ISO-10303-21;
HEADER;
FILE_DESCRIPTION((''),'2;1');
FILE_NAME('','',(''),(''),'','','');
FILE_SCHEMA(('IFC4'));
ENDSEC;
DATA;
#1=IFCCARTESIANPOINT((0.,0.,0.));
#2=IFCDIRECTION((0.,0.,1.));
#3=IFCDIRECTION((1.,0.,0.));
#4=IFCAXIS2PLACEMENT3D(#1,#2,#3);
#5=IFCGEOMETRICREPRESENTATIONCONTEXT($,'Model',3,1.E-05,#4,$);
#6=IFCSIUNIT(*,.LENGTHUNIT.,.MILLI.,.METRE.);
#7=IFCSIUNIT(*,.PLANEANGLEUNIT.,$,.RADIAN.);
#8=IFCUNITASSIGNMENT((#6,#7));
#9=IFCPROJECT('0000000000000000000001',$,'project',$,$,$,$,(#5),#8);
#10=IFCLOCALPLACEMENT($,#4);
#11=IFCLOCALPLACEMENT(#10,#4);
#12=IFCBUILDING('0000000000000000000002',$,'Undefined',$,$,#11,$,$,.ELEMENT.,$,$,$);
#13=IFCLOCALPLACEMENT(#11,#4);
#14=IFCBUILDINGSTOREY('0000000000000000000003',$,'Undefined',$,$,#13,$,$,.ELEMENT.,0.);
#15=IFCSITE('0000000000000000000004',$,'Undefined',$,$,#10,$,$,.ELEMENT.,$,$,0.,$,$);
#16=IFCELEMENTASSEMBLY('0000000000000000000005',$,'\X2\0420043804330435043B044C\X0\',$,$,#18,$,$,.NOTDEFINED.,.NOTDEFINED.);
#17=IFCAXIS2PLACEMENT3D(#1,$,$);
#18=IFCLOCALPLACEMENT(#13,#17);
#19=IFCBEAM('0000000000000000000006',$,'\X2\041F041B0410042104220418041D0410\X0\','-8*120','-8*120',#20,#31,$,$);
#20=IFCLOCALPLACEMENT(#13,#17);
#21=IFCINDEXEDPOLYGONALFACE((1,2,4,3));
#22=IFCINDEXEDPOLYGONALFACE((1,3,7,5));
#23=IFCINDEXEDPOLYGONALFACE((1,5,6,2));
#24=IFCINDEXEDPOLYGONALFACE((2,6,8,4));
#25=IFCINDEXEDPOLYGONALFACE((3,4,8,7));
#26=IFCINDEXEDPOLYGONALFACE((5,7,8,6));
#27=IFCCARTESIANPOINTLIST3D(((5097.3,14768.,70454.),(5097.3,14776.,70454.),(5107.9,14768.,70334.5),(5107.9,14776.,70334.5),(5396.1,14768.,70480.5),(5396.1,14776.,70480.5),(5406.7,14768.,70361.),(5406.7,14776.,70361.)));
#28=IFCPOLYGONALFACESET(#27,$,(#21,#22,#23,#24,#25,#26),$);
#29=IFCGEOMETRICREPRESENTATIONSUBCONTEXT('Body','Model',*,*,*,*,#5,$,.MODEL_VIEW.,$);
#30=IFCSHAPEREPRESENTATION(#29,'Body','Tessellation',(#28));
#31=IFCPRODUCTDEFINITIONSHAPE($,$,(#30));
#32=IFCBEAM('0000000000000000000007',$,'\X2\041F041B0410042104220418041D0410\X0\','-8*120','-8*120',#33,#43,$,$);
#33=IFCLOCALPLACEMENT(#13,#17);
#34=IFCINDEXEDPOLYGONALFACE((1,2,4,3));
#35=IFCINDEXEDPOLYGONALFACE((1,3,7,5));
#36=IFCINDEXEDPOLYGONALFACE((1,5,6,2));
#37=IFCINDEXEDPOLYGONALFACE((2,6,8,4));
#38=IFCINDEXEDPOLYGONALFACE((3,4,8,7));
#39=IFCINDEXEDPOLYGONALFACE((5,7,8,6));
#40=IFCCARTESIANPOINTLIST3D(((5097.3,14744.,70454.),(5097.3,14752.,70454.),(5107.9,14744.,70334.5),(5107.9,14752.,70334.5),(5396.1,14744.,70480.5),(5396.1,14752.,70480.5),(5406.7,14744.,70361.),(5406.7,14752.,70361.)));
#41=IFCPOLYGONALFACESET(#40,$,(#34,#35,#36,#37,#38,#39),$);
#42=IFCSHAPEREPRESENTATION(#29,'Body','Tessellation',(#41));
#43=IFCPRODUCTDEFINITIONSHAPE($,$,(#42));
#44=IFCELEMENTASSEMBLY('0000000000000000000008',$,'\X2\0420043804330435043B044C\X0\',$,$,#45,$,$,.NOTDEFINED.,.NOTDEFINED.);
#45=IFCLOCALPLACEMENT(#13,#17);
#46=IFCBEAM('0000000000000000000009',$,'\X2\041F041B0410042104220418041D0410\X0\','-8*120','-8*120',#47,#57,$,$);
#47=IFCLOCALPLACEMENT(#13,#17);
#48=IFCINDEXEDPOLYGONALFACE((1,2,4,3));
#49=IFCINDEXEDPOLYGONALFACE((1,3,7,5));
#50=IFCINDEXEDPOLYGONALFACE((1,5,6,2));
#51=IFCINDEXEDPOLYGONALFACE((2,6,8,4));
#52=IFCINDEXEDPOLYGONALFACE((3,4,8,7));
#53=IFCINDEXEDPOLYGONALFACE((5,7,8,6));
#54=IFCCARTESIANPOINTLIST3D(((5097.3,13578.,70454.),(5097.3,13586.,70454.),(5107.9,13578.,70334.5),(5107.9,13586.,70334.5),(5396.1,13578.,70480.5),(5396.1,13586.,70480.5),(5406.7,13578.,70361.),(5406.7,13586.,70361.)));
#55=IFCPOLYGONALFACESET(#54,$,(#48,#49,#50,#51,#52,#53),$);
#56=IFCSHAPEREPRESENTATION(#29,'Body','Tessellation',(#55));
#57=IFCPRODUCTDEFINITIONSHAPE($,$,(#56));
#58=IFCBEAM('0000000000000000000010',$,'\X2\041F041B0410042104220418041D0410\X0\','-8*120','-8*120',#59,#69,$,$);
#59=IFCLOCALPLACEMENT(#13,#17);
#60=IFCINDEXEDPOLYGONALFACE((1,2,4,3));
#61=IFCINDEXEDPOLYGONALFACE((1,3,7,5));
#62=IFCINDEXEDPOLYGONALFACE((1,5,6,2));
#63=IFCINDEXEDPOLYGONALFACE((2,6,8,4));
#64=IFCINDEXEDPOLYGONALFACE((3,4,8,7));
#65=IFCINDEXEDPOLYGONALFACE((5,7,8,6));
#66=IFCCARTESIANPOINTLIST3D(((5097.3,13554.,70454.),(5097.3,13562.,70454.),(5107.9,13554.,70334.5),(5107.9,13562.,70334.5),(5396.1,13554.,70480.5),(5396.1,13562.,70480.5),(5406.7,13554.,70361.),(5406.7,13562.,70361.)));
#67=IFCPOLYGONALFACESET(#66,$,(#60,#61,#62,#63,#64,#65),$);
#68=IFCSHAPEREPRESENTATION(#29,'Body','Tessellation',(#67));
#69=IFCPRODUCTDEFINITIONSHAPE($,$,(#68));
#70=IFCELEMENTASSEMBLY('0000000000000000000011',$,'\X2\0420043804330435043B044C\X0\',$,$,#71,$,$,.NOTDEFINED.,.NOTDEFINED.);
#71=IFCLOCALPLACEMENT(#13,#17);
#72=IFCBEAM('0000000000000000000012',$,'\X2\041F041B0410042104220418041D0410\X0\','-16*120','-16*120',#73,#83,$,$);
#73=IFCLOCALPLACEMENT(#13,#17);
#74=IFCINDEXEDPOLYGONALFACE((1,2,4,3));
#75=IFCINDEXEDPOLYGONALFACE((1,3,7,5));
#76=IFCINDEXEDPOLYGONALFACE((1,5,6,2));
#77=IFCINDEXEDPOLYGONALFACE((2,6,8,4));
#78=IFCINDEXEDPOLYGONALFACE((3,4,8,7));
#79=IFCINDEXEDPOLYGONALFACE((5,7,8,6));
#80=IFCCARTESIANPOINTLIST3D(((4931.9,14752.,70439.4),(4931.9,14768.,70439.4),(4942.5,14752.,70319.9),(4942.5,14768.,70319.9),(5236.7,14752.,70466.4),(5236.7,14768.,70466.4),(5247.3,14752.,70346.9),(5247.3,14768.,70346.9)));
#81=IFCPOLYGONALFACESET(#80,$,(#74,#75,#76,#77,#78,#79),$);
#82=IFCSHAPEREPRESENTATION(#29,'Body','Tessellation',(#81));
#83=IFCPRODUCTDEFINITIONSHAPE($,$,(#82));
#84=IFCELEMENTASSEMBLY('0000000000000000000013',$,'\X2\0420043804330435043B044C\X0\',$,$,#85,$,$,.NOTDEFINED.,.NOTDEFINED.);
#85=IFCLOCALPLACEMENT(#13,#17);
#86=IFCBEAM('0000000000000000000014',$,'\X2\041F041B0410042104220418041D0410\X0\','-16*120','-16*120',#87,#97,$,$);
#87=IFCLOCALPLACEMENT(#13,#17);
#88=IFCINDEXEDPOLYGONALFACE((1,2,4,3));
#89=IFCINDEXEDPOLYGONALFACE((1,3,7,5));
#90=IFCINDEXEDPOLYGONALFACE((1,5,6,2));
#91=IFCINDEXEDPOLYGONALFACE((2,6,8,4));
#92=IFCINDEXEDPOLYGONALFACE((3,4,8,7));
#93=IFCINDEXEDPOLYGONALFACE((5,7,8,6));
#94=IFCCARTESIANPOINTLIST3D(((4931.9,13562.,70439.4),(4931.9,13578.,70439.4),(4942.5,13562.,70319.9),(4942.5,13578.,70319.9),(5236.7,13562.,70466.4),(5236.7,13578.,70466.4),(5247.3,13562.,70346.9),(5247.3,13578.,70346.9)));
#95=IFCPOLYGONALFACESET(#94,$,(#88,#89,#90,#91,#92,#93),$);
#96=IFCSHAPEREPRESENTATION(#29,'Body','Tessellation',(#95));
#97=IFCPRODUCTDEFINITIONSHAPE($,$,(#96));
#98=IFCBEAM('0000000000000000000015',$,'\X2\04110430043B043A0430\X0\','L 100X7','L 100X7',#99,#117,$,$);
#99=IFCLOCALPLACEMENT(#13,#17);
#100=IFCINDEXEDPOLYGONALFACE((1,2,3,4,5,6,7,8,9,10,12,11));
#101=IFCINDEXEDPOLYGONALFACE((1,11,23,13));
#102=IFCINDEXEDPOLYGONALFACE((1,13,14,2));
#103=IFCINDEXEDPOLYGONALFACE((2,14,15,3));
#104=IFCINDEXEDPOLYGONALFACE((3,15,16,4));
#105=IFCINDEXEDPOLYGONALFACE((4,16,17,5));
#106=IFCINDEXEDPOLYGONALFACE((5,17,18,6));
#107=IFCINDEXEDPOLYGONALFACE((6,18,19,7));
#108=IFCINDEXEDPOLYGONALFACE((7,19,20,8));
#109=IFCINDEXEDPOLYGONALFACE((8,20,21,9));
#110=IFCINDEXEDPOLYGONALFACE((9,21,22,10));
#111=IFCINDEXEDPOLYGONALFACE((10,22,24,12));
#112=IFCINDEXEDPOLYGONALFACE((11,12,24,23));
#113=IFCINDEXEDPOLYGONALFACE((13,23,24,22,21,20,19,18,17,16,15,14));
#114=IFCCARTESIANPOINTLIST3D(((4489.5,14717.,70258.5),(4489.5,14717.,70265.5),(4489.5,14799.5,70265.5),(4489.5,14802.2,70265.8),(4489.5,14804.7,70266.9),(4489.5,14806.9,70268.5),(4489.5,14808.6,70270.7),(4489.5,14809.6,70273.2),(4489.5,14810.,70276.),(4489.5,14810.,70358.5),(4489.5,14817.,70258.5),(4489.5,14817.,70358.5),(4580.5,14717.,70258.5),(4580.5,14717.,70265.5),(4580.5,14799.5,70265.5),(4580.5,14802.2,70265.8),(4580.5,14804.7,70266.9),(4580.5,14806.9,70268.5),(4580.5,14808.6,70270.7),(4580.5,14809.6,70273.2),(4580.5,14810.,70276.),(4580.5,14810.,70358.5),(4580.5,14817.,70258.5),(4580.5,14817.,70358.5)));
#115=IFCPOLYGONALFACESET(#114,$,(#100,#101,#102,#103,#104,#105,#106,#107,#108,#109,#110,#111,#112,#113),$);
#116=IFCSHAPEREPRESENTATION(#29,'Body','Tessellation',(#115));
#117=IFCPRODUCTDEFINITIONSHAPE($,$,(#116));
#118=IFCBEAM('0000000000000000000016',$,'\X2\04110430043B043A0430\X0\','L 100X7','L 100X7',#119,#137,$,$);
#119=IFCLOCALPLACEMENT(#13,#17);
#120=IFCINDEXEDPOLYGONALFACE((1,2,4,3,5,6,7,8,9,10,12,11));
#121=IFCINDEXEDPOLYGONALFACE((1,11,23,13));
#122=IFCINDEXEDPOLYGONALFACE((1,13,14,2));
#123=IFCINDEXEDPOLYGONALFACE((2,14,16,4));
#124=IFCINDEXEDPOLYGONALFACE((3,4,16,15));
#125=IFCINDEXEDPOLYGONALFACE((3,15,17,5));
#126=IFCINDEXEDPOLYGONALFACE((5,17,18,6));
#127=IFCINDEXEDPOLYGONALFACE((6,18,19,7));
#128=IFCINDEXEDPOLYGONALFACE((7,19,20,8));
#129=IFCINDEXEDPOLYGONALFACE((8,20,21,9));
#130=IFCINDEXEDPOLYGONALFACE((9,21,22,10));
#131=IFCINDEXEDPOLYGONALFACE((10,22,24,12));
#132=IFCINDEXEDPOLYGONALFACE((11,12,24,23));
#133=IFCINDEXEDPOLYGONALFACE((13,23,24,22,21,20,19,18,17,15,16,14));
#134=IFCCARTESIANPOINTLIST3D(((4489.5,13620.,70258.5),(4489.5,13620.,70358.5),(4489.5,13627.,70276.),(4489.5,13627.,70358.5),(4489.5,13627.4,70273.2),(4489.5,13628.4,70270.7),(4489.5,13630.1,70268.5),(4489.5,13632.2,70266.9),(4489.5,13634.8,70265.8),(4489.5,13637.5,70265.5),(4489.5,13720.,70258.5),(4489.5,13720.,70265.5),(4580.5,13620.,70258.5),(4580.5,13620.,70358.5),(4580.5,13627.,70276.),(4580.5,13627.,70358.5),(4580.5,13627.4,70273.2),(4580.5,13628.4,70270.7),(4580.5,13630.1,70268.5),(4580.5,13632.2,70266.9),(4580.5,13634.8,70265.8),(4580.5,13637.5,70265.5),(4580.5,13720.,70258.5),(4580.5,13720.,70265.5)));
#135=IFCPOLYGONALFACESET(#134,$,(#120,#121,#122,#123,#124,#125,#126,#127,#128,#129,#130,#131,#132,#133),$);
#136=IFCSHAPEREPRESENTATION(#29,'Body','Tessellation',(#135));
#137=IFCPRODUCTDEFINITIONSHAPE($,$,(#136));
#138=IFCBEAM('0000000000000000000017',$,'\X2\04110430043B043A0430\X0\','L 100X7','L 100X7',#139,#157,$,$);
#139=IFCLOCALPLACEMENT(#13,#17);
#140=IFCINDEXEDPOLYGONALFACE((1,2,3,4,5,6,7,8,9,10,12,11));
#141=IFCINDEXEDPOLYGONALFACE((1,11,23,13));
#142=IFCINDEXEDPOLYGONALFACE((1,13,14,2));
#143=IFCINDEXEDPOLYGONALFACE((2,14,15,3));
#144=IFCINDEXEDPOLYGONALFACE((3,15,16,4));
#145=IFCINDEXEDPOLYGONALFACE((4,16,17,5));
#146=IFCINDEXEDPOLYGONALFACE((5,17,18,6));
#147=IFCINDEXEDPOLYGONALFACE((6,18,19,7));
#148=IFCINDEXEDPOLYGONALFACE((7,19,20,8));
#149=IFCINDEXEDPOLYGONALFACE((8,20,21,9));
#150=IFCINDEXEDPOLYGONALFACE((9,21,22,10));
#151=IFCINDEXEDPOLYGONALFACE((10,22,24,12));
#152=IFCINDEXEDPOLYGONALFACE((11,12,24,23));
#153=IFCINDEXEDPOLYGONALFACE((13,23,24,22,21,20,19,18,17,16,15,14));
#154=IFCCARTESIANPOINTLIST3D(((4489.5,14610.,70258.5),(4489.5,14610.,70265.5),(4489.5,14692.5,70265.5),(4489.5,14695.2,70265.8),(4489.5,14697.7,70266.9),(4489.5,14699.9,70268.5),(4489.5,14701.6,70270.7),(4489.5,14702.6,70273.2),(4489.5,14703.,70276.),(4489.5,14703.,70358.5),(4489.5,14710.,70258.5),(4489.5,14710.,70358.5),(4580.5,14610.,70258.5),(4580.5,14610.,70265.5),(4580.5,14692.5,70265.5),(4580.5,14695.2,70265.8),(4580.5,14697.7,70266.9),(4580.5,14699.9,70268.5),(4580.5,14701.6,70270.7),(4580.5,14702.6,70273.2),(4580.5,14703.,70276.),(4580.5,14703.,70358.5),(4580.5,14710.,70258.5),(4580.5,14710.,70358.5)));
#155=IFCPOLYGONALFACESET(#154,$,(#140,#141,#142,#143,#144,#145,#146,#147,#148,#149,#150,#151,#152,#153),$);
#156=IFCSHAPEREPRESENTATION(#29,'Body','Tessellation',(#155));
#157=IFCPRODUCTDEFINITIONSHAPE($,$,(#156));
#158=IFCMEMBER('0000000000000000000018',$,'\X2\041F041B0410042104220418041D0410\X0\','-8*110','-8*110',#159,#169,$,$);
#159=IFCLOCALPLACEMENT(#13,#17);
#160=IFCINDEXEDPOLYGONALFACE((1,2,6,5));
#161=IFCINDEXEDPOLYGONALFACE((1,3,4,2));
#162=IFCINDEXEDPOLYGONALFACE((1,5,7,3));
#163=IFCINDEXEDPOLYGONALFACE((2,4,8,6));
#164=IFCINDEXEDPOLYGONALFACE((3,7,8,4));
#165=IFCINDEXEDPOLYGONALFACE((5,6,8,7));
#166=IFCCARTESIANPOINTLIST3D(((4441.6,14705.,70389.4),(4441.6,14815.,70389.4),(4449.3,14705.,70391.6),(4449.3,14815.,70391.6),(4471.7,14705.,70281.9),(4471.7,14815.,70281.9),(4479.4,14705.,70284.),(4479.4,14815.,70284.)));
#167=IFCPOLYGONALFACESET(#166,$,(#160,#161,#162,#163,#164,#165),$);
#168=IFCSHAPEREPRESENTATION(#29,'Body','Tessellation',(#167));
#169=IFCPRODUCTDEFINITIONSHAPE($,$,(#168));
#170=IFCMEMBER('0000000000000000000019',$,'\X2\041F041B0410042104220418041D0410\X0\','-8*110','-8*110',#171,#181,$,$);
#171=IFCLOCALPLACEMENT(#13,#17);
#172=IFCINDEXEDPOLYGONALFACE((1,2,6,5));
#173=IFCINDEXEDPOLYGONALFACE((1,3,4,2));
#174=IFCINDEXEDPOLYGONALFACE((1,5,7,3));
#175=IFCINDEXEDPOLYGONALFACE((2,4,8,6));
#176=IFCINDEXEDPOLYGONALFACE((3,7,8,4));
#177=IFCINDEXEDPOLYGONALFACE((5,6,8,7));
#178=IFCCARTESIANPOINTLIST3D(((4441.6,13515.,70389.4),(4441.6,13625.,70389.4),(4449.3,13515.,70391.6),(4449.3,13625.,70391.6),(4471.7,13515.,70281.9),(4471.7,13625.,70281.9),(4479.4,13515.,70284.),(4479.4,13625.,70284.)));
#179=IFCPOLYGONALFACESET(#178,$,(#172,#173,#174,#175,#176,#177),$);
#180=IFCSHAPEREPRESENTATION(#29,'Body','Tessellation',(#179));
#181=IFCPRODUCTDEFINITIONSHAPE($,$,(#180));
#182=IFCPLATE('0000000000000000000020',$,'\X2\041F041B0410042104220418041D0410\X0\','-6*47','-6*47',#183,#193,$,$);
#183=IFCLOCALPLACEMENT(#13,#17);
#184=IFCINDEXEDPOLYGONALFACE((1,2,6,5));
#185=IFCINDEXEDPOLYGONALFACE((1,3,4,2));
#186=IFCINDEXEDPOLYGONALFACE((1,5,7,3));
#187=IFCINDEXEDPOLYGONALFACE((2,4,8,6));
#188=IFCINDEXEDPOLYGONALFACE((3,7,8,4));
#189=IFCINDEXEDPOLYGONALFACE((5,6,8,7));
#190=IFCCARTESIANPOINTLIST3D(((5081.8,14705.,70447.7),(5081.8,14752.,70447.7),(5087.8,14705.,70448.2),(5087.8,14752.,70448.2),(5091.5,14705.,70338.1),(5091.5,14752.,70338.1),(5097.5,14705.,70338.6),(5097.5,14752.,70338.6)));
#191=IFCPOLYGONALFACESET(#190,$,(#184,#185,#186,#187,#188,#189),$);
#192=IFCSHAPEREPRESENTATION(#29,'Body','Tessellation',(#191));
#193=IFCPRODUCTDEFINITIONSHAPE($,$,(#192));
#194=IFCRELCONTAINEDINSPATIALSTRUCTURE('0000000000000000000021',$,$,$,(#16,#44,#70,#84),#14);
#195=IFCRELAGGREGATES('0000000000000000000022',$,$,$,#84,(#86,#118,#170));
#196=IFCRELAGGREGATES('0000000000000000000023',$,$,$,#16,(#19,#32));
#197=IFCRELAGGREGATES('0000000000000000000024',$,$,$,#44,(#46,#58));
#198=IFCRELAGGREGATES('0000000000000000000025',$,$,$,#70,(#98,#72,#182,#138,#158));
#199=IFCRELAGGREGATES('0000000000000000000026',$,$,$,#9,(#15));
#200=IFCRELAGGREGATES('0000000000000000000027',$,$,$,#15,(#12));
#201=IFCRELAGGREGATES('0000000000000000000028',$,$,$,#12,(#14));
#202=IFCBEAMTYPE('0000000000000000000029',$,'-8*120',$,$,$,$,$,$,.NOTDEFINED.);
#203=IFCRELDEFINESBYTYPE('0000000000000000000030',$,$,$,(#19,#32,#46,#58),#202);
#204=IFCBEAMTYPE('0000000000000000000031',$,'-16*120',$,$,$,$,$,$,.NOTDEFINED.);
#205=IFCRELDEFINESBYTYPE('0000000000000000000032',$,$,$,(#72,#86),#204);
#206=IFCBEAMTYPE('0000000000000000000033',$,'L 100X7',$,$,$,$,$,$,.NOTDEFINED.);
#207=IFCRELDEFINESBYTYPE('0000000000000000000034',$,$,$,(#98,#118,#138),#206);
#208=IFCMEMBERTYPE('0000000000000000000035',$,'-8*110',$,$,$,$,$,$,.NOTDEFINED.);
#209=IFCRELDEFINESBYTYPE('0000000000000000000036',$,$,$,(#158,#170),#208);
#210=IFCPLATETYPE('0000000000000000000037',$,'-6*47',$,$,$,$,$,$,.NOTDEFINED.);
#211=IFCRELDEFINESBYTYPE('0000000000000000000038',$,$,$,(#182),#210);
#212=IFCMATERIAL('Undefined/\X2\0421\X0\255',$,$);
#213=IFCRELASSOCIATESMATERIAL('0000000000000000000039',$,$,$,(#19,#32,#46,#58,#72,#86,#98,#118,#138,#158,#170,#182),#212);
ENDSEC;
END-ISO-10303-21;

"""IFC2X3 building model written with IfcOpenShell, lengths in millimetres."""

from ifc_helpers import new_model, si_unit, frame, origin_with_axes, origin_2d_with_axis, place, context, subcontext, project, spatial, polyline, rectangle, l_section, outline, extrude, boolean, material, type_object, element, aggregate, save


model = new_model("IFC2X3")

# Units and contexts
model_context = context("Model", 3, precision=1e-05, world=origin_with_axes())
body_context = subcontext(model_context, "Body", "Model", "MODEL_VIEW")
ifc_project = project(units=[si_unit("LENGTHUNIT", "METRE", prefix="MILLI"), si_unit("PLANEANGLEUNIT", "RADIAN")], contexts=[model_context])

# Site, building, storey
site_placement = place(None, origin_with_axes())
site = spatial("IfcSite", under=ifc_project, at=site_placement, Name="Undefined", CompositionType="ELEMENT", RefElevation=0.0)
building_placement = place(site_placement, origin_with_axes())
building = spatial("IfcBuilding", under=site, at=building_placement, Name="Undefined", CompositionType="ELEMENT")
storey_placement = place(building_placement, origin_with_axes())
storey = spatial("IfcBuildingStorey", under=building, at=storey_placement, Name="Undefined", CompositionType="ELEMENT", Elevation=0.0)

# Element assemblies, beams
assembly_1_placement = place(storey_placement, origin_with_axes())
assembly_1 = element("IfcElementAssembly", 1, at=assembly_1_placement, inside=storey, Name="Ригель", AssemblyPlace="NOTDEFINED", PredefinedType="NOTDEFINED")
ifc_material_1 = material(Name="Undefined/С255")
beam_type_1 = type_object("IfcBeamType", Name="-8*120", PredefinedType="NOTDEFINED")
beam_1_placement = place(assembly_1_placement, frame((5102.6, 14772.0, 70394.3), z_axis=(0.088152, 0.0, -0.996107), x_axis=(0.996107, 0.0, 0.088152)))
beam_1 = element("IfcBeam", 2, at=beam_1_placement, type_object=beam_type_1, material=ifc_material_1, Name="ПЛАСТИНА", Description="-8*120", ObjectType="-8*120", context=body_context, shape_type="SweptSolid", body=[
    extrude(rectangle(XDim=8.0, YDim=120.0, at=origin_2d_with_axis()), frame((300.0, 0.0, 0.0), z_axis=(-1.0, 0.0, 0.0), x_axis=(0.0, -1.0, 0.0)), (0.0, 0.0, 1.0), 300.0),
])
beam_2_placement = place(assembly_1_placement, frame((5102.6, 14748.0, 70394.3), z_axis=(0.088152, 0.0, -0.996107), x_axis=(0.996107, 0.0, 0.088152)))
beam_2 = element("IfcBeam", 3, at=beam_2_placement, type_object=beam_type_1, material=ifc_material_1, Name="ПЛАСТИНА", Description="-8*120", ObjectType="-8*120", context=body_context, shape_type="SweptSolid", body=[
    extrude(rectangle(XDim=8.0, YDim=120.0, at=origin_2d_with_axis()), frame((300.0, 0.0, 0.0), z_axis=(-1.0, 0.0, 0.0), x_axis=(0.0, -1.0, 0.0)), (0.0, 0.0, 1.0), 300.0),
])
assembly_2_placement = place(storey_placement, origin_with_axes())
assembly_2 = element("IfcElementAssembly", 4, at=assembly_2_placement, inside=storey, Name="Ригель", AssemblyPlace="NOTDEFINED", PredefinedType="NOTDEFINED")
beam_3_placement = place(assembly_2_placement, frame((5102.6, 13582.0, 70394.3), z_axis=(0.088152, 0.0, -0.996107), x_axis=(0.996107, 0.0, 0.088152)))
beam_3 = element("IfcBeam", 5, at=beam_3_placement, type_object=beam_type_1, material=ifc_material_1, Name="ПЛАСТИНА", Description="-8*120", ObjectType="-8*120", context=body_context, shape_type="SweptSolid", body=[
    extrude(rectangle(XDim=8.0, YDim=120.0, at=origin_2d_with_axis()), frame((300.0, 0.0, 0.0), z_axis=(-1.0, 0.0, 0.0), x_axis=(0.0, -1.0, 0.0)), (0.0, 0.0, 1.0), 300.0),
])
beam_4_placement = place(assembly_2_placement, frame((5102.6, 13558.0, 70394.3), z_axis=(0.088152, 0.0, -0.996107), x_axis=(0.996107, 0.0, 0.088152)))
beam_4 = element("IfcBeam", 6, at=beam_4_placement, type_object=beam_type_1, material=ifc_material_1, Name="ПЛАСТИНА", Description="-8*120", ObjectType="-8*120", context=body_context, shape_type="SweptSolid", body=[
    extrude(rectangle(XDim=8.0, YDim=120.0, at=origin_2d_with_axis()), frame((300.0, 0.0, 0.0), z_axis=(-1.0, 0.0, 0.0), x_axis=(0.0, -1.0, 0.0)), (0.0, 0.0, 1.0), 300.0),
])

# Element assemblies, beams
assembly_3_placement = place(storey_placement, origin_with_axes())
assembly_3 = element("IfcElementAssembly", 7, at=assembly_3_placement, inside=storey, Name="Ригель", AssemblyPlace="NOTDEFINED", PredefinedType="NOTDEFINED")
beam_type_2 = type_object("IfcBeamType", Name="-16*120", PredefinedType="NOTDEFINED")
beam_5_placement = place(assembly_3_placement, frame((4937.2, 14760.0, 70379.6), z_axis=(0.088152, 0.0, -0.996107), x_axis=(0.996107, 0.0, 0.088152)))
beam_5 = element("IfcBeam", 8, at=beam_5_placement, type_object=beam_type_2, material=ifc_material_1, Name="ПЛАСТИНА", Description="-16*120", ObjectType="-16*120", context=body_context, shape_type="SweptSolid", body=[
    extrude(rectangle(XDim=16.0, YDim=120.0, at=origin_2d_with_axis()), frame((306.0, 0.0, 0.0), z_axis=(-1.0, 0.0, 0.0), x_axis=(0.0, -1.0, 0.0)), (0.0, 0.0, 1.0), 306.0),
])
assembly_4_placement = place(storey_placement, origin_with_axes())
assembly_4 = element("IfcElementAssembly", 9, at=assembly_4_placement, inside=storey, Name="Ригель", AssemblyPlace="NOTDEFINED", PredefinedType="NOTDEFINED")
beam_6_placement = place(assembly_4_placement, frame((4937.2, 13570.0, 70379.6), z_axis=(0.088152, 0.0, -0.996107), x_axis=(0.996107, 0.0, 0.088152)))
beam_6 = element("IfcBeam", 10, at=beam_6_placement, type_object=beam_type_2, material=ifc_material_1, Name="ПЛАСТИНА", Description="-16*120", ObjectType="-16*120", context=body_context, shape_type="SweptSolid", body=[
    extrude(rectangle(XDim=16.0, YDim=120.0, at=origin_2d_with_axis()), frame((306.0, 0.0, 0.0), z_axis=(-1.0, 0.0, 0.0), x_axis=(0.0, -1.0, 0.0)), (0.0, 0.0, 1.0), 306.0),
])

# Beams
beam_type_3 = type_object("IfcBeamType", Name="L 100X7", PredefinedType="NOTDEFINED")
beam_7_placement = place(assembly_3_placement, frame((4489.5, 14767.0, 70308.5), z_axis=(0.0, 0.0, 1.0), x_axis=(1.0, 0.0, 0.0)))
beam_7 = element("IfcBeam", 11, at=beam_7_placement, type_object=beam_type_3, material=ifc_material_1, Name="Балка", Description="L 100X7", ObjectType="L 100X7", context=body_context, shape_type="SweptSolid", body=[
    extrude(l_section(Depth=100.0, Width=100.0, Thickness=7.0, FilletRadius=10.5, at=origin_2d_with_axis()), frame((91.0, 0.0, 0.0), z_axis=(-1.0, 0.0, 0.0), x_axis=(0.0, -1.0, 0.0)), (0.0, 0.0, 1.0), 91.0),
])
beam_8_placement = place(assembly_4_placement, frame((4489.5, 13670.0, 70308.5), z_axis=(0.0, 1.0, 0.0), x_axis=(1.0, 0.0, 0.0)))
beam_8 = element("IfcBeam", 12, at=beam_8_placement, type_object=beam_type_3, material=ifc_material_1, Name="Балка", Description="L 100X7", ObjectType="L 100X7", context=body_context, shape_type="SweptSolid", body=[
    extrude(l_section(Depth=100.0, Width=100.0, Thickness=7.0, FilletRadius=10.5, at=origin_2d_with_axis()), frame((91.0, 0.0, 0.0), z_axis=(-1.0, 0.0, 0.0), x_axis=(0.0, -1.0, 0.0)), (0.0, 0.0, 1.0), 91.0),
])
beam_9_placement = place(assembly_3_placement, frame((4489.5, 14660.0, 70308.5), z_axis=(0.0, 0.0, 1.0), x_axis=(1.0, 0.0, 0.0)))
beam_9 = element("IfcBeam", 13, at=beam_9_placement, type_object=beam_type_3, material=ifc_material_1, Name="Балка", Description="L 100X7", ObjectType="L 100X7", context=body_context, shape_type="SweptSolid", body=[
    extrude(l_section(Depth=100.0, Width=100.0, Thickness=7.0, FilletRadius=10.5, at=origin_2d_with_axis()), frame((91.0, 0.0, 0.0), z_axis=(-1.0, 0.0, 0.0), x_axis=(0.0, -1.0, 0.0)), (0.0, 0.0, 1.0), 91.0),
])

# Members
member_type = type_object("IfcMemberType", Name="-8*110", PredefinedType="NOTDEFINED")
member_1_placement = place(assembly_3_placement, frame((4475.6, 14760.0, 70282.9), z_axis=(0.0, -1.0, 0.0), x_axis=(-0.269248, 0.0, 0.963071)))
member_1 = element("IfcMember", 14, at=member_1_placement, type_object=member_type, material=ifc_material_1, Name="ПЛАСТИНА", Description="-8*110", ObjectType="-8*110", context=body_context, shape_type="SweptSolid", body=[
    extrude(rectangle(XDim=8.0, YDim=110.0, at=origin_2d_with_axis()), frame((111.7, 0.0, 0.0), z_axis=(-1.0, 0.0, 0.0), x_axis=(0.0, -1.0, 0.0)), (0.0, 0.0, 1.0), 111.7),
])
member_2_placement = place(assembly_4_placement, frame((4475.6, 13570.0, 70282.9), z_axis=(0.0, -1.0, 0.0), x_axis=(-0.269248, 0.0, 0.963071)))
member_2 = element("IfcMember", 15, at=member_2_placement, type_object=member_type, material=ifc_material_1, Name="ПЛАСТИНА", Description="-8*110", ObjectType="-8*110", context=body_context, shape_type="SweptSolid", body=[
    extrude(rectangle(XDim=8.0, YDim=110.0, at=origin_2d_with_axis()), frame((111.7, 0.0, 0.0), z_axis=(-1.0, 0.0, 0.0), x_axis=(0.0, -1.0, 0.0)), (0.0, 0.0, 1.0), 111.7),
])

# Plate
plate_type_1 = type_object("IfcPlateType", Name="-6*47", PredefinedType="NOTDEFINED")
plate_1_placement = place(assembly_3_placement, frame((5084.8, 14705.0, 70447.9), z_axis=(0.996107, 0.0, 0.088152), x_axis=(0.088152, 0.0, -0.996107)))
plate_1 = element("IfcPlate", 16, at=plate_1_placement, type_object=plate_type_1, material=ifc_material_1, Name="ПЛАСТИНА", Description="-6*47", ObjectType="-6*47", context=body_context, shape_type="CSG", body=[
    boolean("DIFFERENCE", extrude(outline(polyline([(0.0, 0.0), (110.0, 0.0), (110.0, 110.0), (0.0, 110.0), (0.0, 0.0)])), frame((0.0, 0.0, -3.0), z_axis=(0.0, 0.0, 1.0), x_axis=(1.0, 0.0, 0.0)), (0.0, 0.0, 1.0), 6.0), extrude(rectangle(XDim=26.0, YDim=130.0, at=origin_2d_with_axis()), frame((55.0, 47.0, 0.0), z_axis=(0.0, 1.0, 0.0), x_axis=(0.0, 0.0, -1.0)), (0.0, 0.0, 1.0), 66.0)),
])
aggregate(assembly_4, [beam_6, beam_8, member_2])

aggregate(assembly_1, [beam_1, beam_2])
aggregate(assembly_2, [beam_3, beam_4])
aggregate(assembly_3, [beam_7, beam_5, plate_1, beam_9, member_1])

save(model, "model.ifc")
